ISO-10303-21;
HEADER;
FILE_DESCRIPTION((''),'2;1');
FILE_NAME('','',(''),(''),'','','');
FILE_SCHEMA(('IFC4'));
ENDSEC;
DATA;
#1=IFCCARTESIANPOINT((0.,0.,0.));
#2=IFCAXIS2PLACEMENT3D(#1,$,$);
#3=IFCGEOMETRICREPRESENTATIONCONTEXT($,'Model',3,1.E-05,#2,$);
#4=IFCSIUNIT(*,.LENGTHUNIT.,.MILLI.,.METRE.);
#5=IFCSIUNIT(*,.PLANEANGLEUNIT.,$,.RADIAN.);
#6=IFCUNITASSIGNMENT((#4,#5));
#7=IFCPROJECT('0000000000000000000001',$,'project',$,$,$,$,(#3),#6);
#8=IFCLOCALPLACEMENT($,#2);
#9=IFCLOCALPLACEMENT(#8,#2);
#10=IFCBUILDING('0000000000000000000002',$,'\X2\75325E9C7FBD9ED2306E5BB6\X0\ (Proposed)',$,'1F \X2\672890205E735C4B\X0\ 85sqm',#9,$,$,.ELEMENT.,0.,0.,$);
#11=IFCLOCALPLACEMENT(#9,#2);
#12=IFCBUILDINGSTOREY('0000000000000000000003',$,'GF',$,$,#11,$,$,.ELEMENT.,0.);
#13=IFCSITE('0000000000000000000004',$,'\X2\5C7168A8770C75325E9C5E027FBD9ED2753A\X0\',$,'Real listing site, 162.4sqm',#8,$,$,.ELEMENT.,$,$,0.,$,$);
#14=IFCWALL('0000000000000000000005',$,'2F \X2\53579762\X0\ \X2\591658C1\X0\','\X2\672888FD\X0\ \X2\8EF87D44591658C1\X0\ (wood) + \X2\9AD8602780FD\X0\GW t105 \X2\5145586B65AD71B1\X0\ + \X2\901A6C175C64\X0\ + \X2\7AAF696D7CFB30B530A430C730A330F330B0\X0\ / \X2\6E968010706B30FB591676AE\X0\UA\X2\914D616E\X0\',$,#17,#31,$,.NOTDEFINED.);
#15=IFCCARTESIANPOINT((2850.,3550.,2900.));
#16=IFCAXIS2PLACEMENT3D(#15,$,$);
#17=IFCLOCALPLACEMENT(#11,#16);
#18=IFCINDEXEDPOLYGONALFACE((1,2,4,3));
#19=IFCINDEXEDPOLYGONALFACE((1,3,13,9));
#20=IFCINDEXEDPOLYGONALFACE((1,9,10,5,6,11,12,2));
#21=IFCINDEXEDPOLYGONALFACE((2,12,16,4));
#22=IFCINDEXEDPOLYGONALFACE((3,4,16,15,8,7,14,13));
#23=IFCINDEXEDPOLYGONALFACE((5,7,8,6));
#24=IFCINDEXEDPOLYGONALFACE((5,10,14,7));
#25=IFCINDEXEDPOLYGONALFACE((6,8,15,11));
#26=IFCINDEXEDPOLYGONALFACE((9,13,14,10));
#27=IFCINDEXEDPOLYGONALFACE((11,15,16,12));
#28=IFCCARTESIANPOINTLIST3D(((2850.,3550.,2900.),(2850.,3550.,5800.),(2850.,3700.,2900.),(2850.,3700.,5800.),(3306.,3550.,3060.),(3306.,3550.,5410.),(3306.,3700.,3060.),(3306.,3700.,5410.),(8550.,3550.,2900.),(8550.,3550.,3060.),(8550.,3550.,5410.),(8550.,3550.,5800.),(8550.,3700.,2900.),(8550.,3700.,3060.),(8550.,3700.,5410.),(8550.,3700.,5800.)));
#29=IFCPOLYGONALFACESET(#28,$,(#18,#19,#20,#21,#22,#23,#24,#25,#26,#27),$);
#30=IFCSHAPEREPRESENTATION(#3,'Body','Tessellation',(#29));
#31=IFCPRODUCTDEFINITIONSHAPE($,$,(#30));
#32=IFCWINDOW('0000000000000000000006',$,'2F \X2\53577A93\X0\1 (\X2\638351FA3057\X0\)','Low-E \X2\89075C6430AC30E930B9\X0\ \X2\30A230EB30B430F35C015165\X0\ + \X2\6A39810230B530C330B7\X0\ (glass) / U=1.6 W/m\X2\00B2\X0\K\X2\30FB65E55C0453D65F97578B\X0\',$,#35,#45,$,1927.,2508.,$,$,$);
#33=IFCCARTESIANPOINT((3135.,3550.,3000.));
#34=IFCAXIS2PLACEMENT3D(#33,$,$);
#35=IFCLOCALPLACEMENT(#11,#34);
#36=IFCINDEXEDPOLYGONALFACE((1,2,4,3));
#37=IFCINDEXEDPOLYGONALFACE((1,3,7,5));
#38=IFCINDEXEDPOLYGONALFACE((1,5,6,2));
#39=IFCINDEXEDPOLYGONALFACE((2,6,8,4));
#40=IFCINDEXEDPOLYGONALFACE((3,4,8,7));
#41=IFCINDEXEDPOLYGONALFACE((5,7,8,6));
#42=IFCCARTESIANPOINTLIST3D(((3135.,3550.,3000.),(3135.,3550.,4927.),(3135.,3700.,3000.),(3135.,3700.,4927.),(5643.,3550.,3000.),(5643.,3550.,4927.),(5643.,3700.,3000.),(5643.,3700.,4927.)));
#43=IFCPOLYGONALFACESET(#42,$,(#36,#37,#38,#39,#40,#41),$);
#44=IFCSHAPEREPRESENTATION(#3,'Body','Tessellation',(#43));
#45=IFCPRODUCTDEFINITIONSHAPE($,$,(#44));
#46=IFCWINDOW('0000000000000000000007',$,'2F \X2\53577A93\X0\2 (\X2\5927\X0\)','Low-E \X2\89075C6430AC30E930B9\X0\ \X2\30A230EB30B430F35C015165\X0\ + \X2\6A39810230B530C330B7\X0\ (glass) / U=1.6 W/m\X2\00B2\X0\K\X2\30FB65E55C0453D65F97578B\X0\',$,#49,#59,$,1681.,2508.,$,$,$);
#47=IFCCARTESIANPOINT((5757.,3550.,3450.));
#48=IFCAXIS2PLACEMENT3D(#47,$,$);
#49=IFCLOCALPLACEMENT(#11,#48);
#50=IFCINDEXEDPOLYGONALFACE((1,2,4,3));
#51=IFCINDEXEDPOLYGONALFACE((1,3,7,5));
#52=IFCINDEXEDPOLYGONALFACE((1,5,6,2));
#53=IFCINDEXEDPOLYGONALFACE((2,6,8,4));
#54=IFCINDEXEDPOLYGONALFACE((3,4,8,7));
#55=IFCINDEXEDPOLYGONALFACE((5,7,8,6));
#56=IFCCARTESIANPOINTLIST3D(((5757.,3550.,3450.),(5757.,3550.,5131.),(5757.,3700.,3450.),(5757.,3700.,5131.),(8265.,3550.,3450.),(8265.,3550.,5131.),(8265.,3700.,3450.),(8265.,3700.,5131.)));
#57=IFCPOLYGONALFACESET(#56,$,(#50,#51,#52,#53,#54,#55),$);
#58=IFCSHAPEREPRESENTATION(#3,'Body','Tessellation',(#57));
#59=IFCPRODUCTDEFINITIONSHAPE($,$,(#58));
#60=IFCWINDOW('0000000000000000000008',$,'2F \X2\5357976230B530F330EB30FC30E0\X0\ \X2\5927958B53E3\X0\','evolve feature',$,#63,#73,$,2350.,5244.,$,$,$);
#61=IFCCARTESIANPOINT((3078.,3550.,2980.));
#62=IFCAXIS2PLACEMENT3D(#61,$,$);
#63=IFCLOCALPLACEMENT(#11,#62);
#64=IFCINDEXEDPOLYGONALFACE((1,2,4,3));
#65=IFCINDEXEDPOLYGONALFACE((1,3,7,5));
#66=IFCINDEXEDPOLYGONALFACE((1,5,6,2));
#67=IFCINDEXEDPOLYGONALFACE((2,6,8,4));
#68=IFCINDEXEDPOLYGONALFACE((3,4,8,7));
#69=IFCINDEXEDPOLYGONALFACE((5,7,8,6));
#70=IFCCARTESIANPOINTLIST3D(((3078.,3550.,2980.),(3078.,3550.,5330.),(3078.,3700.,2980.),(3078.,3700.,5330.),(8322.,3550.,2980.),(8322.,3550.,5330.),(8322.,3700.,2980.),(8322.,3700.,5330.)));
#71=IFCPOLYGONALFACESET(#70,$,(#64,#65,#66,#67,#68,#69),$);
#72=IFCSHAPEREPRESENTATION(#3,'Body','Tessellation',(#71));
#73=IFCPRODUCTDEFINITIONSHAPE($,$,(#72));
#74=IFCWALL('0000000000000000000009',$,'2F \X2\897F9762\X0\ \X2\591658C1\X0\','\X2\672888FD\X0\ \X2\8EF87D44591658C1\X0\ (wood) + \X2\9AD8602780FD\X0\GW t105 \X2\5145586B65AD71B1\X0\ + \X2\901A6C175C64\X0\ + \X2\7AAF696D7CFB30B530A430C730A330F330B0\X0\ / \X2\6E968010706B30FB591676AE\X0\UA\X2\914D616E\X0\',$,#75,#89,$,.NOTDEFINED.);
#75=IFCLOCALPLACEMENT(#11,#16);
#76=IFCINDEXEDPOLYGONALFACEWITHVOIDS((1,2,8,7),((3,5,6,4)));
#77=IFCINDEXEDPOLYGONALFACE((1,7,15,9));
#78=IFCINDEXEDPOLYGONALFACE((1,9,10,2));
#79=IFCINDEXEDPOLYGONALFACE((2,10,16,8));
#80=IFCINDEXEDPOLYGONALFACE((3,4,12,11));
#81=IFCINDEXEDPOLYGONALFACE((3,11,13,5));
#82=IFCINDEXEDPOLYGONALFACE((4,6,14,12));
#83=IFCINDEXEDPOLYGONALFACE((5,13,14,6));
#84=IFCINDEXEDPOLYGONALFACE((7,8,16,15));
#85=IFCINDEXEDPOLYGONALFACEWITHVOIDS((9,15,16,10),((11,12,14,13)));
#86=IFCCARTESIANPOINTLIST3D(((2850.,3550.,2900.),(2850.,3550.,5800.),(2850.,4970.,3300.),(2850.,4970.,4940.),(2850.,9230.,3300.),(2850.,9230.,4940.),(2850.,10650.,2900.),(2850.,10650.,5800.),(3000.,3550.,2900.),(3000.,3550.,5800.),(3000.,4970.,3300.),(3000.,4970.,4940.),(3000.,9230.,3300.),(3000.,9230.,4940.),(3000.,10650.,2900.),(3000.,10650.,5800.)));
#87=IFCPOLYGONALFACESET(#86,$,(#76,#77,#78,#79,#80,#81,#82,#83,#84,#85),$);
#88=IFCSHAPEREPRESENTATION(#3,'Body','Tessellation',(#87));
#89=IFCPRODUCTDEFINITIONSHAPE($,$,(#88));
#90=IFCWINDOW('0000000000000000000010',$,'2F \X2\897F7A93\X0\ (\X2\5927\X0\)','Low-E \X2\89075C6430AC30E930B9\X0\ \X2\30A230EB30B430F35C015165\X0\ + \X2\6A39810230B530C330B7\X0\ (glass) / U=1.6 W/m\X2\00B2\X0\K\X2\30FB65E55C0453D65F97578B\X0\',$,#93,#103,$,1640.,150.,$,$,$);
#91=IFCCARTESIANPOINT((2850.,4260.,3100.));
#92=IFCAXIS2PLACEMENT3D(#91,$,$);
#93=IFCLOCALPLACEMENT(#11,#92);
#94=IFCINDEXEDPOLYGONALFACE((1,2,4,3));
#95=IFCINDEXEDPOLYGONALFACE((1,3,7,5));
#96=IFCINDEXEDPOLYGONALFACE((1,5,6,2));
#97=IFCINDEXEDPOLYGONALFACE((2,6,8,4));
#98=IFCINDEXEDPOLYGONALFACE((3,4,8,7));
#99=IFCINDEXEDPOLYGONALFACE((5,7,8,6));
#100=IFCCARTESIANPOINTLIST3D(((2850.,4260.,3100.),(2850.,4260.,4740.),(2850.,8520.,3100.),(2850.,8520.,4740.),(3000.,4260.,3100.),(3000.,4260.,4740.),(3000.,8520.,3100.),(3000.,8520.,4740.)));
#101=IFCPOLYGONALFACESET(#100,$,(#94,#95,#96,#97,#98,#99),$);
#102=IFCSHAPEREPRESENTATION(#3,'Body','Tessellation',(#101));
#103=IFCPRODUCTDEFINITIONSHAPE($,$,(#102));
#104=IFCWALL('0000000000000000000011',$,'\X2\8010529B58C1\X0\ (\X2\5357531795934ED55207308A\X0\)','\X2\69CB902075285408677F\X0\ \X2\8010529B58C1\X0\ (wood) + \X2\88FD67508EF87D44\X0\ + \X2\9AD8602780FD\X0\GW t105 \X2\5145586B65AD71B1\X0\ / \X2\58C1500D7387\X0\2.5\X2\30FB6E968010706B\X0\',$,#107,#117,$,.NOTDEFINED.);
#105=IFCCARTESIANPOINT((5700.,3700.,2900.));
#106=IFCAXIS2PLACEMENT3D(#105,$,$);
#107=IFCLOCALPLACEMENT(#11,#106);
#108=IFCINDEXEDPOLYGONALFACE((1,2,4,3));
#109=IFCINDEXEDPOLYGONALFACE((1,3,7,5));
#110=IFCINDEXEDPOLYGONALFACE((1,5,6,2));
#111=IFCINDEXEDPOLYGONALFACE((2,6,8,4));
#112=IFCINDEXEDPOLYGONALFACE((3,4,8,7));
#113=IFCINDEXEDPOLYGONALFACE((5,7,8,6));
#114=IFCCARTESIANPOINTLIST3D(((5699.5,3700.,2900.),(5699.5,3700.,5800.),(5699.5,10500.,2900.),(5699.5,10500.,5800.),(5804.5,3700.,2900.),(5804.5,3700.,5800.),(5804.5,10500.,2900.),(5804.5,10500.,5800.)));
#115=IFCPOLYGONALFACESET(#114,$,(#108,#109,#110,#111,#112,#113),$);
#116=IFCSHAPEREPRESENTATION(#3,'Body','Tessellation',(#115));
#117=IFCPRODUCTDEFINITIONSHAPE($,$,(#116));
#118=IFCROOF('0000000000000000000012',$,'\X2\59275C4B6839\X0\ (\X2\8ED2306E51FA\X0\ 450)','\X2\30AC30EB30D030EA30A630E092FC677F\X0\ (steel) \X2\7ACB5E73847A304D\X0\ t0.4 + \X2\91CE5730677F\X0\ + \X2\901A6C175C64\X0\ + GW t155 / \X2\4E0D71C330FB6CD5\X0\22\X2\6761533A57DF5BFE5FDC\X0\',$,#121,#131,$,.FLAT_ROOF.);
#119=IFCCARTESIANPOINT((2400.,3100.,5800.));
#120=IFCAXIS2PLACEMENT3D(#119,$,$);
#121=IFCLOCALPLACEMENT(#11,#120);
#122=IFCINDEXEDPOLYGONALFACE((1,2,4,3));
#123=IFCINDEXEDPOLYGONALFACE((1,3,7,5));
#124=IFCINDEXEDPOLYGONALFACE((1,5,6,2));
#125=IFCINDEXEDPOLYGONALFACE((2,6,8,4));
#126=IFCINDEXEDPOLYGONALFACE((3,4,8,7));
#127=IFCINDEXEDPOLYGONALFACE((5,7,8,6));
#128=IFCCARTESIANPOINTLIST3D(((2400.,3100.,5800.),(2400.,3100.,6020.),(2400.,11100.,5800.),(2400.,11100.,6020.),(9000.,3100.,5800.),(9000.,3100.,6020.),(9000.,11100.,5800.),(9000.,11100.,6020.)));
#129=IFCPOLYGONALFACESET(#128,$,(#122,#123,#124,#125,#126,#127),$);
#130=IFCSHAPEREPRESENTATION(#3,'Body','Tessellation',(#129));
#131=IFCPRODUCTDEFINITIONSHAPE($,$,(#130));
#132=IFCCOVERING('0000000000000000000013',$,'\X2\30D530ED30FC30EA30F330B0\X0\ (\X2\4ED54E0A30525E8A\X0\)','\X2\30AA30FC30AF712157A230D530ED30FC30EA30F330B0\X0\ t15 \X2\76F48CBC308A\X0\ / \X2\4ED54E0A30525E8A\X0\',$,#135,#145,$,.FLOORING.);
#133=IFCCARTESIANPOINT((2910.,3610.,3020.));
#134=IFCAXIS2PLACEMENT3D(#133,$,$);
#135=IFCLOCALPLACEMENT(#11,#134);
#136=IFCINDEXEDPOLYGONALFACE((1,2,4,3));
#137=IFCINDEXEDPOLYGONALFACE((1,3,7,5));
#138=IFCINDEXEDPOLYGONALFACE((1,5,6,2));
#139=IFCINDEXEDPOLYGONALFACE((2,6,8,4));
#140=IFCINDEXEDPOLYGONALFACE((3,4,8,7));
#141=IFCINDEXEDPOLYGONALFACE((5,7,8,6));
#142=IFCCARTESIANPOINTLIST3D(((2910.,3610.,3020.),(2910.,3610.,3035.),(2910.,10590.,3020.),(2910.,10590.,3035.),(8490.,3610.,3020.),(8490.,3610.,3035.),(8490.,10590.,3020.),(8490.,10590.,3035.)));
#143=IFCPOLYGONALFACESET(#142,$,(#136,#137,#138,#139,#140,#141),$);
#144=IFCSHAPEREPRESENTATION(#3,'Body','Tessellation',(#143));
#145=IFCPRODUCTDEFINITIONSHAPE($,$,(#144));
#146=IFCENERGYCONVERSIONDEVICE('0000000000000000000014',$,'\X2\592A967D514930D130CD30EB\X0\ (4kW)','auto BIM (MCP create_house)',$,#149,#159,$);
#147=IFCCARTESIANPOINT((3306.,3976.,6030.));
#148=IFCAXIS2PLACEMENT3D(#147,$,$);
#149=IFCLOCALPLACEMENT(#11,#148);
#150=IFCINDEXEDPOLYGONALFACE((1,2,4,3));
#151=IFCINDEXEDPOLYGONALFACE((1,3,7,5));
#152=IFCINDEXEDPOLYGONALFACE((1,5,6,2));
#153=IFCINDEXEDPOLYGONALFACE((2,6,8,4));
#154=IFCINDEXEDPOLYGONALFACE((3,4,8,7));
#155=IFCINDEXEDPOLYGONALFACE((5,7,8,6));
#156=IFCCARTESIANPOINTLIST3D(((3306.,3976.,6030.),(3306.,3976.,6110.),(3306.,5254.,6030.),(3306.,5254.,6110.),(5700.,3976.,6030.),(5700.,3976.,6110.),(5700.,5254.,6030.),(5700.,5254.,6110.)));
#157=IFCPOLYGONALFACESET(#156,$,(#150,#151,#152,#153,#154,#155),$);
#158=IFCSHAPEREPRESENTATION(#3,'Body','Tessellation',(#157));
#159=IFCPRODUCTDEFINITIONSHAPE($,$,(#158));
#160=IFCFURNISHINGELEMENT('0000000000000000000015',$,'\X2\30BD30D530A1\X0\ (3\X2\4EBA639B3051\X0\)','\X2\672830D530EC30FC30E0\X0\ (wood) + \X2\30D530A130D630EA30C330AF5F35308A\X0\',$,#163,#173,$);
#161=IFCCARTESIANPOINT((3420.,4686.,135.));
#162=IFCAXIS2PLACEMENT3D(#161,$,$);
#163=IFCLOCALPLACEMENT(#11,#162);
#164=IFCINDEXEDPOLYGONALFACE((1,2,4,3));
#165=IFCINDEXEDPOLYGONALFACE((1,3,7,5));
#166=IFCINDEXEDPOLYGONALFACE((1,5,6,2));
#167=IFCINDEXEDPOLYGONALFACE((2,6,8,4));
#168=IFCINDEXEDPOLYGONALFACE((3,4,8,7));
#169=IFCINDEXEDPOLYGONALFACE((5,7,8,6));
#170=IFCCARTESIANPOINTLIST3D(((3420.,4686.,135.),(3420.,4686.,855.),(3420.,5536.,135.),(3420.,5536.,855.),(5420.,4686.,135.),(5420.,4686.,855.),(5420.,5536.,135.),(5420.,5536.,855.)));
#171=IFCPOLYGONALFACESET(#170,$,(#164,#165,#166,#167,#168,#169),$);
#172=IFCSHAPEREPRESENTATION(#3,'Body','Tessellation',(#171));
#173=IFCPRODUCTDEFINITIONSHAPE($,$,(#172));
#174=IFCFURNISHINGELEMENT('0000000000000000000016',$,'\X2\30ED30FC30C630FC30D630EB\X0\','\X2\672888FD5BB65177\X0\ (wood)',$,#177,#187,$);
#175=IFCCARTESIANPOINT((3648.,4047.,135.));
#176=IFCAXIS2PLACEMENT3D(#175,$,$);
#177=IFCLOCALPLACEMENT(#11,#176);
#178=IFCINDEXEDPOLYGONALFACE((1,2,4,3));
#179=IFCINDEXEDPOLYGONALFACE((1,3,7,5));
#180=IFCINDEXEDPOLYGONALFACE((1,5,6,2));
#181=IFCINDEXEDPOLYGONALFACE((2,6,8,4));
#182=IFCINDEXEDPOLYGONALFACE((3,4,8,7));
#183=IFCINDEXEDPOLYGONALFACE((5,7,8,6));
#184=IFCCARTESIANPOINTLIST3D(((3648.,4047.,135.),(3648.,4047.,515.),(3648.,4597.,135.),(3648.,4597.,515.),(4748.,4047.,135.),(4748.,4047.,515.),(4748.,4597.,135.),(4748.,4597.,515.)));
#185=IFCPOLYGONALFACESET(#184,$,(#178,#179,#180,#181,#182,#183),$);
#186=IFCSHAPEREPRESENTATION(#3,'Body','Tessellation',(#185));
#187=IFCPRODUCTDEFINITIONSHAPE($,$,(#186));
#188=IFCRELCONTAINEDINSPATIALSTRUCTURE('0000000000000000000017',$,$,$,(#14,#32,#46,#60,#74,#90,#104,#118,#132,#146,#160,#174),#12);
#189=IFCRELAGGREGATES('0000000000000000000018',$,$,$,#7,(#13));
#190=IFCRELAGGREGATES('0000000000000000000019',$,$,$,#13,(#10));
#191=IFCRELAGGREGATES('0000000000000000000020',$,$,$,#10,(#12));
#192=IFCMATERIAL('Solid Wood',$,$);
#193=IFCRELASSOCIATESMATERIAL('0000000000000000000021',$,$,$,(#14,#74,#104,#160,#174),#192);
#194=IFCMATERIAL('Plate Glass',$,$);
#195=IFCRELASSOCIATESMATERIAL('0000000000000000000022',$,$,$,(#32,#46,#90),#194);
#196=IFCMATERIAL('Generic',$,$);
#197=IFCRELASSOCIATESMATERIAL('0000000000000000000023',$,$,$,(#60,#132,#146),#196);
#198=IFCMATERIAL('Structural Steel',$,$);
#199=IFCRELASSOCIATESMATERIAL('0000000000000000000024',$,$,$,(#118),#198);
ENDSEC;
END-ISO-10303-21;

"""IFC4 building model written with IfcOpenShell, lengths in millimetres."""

from ifc_helpers import new_model, si_unit, frame, frame_2d, origin, place, context, project, spatial, rectangle, extrude, material, element, fill, save


model = new_model("IFC4")

# Units and contexts
model_context = context("Model", 3, precision=1e-05, world=origin())
ifc_project = project(units=[si_unit("LENGTHUNIT", "METRE", prefix="MILLI"), si_unit("PLANEANGLEUNIT", "RADIAN")], contexts=[model_context])

# Site, building, storey
site_placement = place(None, origin())
site = spatial("IfcSite", under=ifc_project, at=site_placement, Name="山梨県甲府市羽黒町", ObjectType="Real listing site, 162.4sqm", CompositionType="ELEMENT", RefElevation=0.0)
building_placement = place(site_placement, origin())
building = spatial("IfcBuilding", under=site, at=building_placement, Name="甲府羽黒の家 (Proposed)", ObjectType="1F 木造平屋 85sqm", CompositionType="ELEMENT", ElevationOfRefHeight=0.0, ElevationOfTerrain=0.0)
storey_placement = place(building_placement, origin())
storey = spatial("IfcBuildingStorey", under=building, at=storey_placement, Name="GF", CompositionType="ELEMENT", Elevation=0.0)

# Shared definitions
ifc_material_1 = material(Name="Solid Wood")

# Wall, openings, windows
wall_1_placement = place(storey_placement, frame((2850.0, 3550.0, 2900.0)))
wall_1 = element("IfcWall", 1, at=wall_1_placement, inside=storey, material=ifc_material_1, Name="2F 南面 外壁", Description="木製 軸組外壁 (wood) + 高性能GW t105 充填断熱 + 通気層 + 窯業系サイディング / 準耐火・外皮UA配慮", PredefinedType="NOTDEFINED", context=model_context, shape_type="SweptSolid", body=[
    extrude(rectangle(XDim=5700.0, YDim=150.0, at=frame_2d((2850.0, 75.0))), frame((2850.0, 3550.0, 2900.0)), (0.0, 0.0, 1.0), 2900.0),
])
opening_1_placement = place(storey_placement, frame((3135.0, 3550.0, 3000.0)))
opening_1 = element("IfcOpeningElement", 2, at=opening_1_placement, cuts=wall_1, PredefinedType="NOTDEFINED", context=model_context, shape_type="SweptSolid", body=[
    extrude(rectangle(XDim=2508.0, YDim=150.0, at=frame_2d((1254.0, 75.0))), frame((3135.0, 3550.0, 3000.0)), (0.0, 0.0, 1.0), 1927.0),
])
opening_2_placement = place(storey_placement, frame((5757.0, 3550.0, 3450.0)))
opening_2 = element("IfcOpeningElement", 3, at=opening_2_placement, cuts=wall_1, PredefinedType="NOTDEFINED", context=model_context, shape_type="SweptSolid", body=[
    extrude(rectangle(XDim=2508.0, YDim=150.0, at=frame_2d((1254.0, 75.0))), frame((5757.0, 3550.0, 3450.0)), (0.0, 0.0, 1.0), 1681.0),
])
opening_3_placement = place(storey_placement, frame((3078.0, 3550.0, 2980.0)))
opening_3 = element("IfcOpeningElement", 4, at=opening_3_placement, cuts=wall_1, PredefinedType="NOTDEFINED", context=model_context, shape_type="SweptSolid", body=[
    extrude(rectangle(XDim=5244.0, YDim=150.0, at=frame_2d((2622.0, 75.0))), frame((3078.0, 3550.0, 2980.0)), (0.0, 0.0, 1.0), 2350.0),
])
ifc_material_2 = material(Name="Plate Glass")
window_1_placement = place(storey_placement, frame((3135.0, 3550.0, 3000.0)))
window_1 = element("IfcWindow", 5, at=window_1_placement, inside=storey, material=ifc_material_2, Name="2F 南窓1 (掃出し)", Description="Low-E 複層ガラス アルゴン封入 + 樹脂サッシ (glass) / U=1.6 W/m²K・日射取得型", OverallHeight=1927.0, OverallWidth=2508.0, context=model_context, shape_type="SweptSolid", body=[
    extrude(rectangle(XDim=2508.0, YDim=150.0, at=frame_2d((1254.0, 75.0))), frame((3135.0, 3550.0, 3000.0)), (0.0, 0.0, 1.0), 1927.0),
])
fill(opening_1, window_1)
window_2_placement = place(storey_placement, frame((5757.0, 3550.0, 3450.0)))
window_2 = element("IfcWindow", 6, at=window_2_placement, inside=storey, material=ifc_material_2, Name="2F 南窓2 (大)", Description="Low-E 複層ガラス アルゴン封入 + 樹脂サッシ (glass) / U=1.6 W/m²K・日射取得型", OverallHeight=1681.0, OverallWidth=2508.0, context=model_context, shape_type="SweptSolid", body=[
    extrude(rectangle(XDim=2508.0, YDim=150.0, at=frame_2d((1254.0, 75.0))), frame((5757.0, 3550.0, 3450.0)), (0.0, 0.0, 1.0), 1681.0),
])
fill(opening_2, window_2)
ifc_material_3 = material(Name="Generic")
window_3_placement = place(storey_placement, frame((3078.0, 3550.0, 2980.0)))
window_3 = element("IfcWindow", 7, at=window_3_placement, inside=storey, material=ifc_material_3, Name="2F 南面サンルーム 大開口", Description="evolve feature", OverallHeight=2350.0, OverallWidth=5244.0, context=model_context, shape_type="SweptSolid", body=[
    extrude(rectangle(XDim=5244.0, YDim=150.0, at=frame_2d((2622.0, 75.0))), frame((3078.0, 3550.0, 2980.0)), (0.0, 0.0, 1.0), 2350.0),
])
fill(opening_3, window_3)

# Wall, opening, window
wall_2_placement = place(storey_placement, frame((2850.0, 3550.0, 2900.0)))
wall_2 = element("IfcWall", 8, at=wall_2_placement, inside=storey, material=ifc_material_1, Name="2F 西面 外壁", Description="木製 軸組外壁 (wood) + 高性能GW t105 充填断熱 + 通気層 + 窯業系サイディング / 準耐火・外皮UA配慮", PredefinedType="NOTDEFINED", context=model_context, shape_type="SweptSolid", body=[
    extrude(rectangle(XDim=150.0, YDim=7100.0, at=frame_2d((75.0, 3550.0))), frame((2850.0, 3550.0, 2900.0)), (0.0, 0.0, 1.0), 2900.0),
])
opening_4_placement = place(storey_placement, frame((2850.0, 4260.0, 3100.0)))
opening_4 = element("IfcOpeningElement", 9, at=opening_4_placement, cuts=wall_2, PredefinedType="NOTDEFINED", context=model_context, shape_type="SweptSolid", body=[
    extrude(rectangle(XDim=150.0, YDim=4260.0, at=frame_2d((75.0, 2130.0))), frame((2850.0, 4260.0, 3100.0)), (0.0, 0.0, 1.0), 1640.0),
])
window_4_placement = place(storey_placement, frame((2850.0, 4260.0, 3100.0)))
window_4 = element("IfcWindow", 10, at=window_4_placement, inside=storey, material=ifc_material_2, Name="2F 西窓 (大)", Description="Low-E 複層ガラス アルゴン封入 + 樹脂サッシ (glass) / U=1.6 W/m²K・日射取得型", OverallHeight=1640.0, OverallWidth=150.0, context=model_context, shape_type="SweptSolid", body=[
    extrude(rectangle(XDim=150.0, YDim=4260.0, at=frame_2d((75.0, 2130.0))), frame((2850.0, 4260.0, 3100.0)), (0.0, 0.0, 1.0), 1640.0),
])
fill(opening_4, window_4)

# Wall
wall_3_placement = place(storey_placement, frame((5700.0, 3700.0, 2900.0)))
element("IfcWall", 11, at=wall_3_placement, inside=storey, material=ifc_material_1, Name="耐力壁 (南北間仕切り)", Description="構造用合板 耐力壁 (wood) + 製材軸組 + 高性能GW t105 充填断熱 / 壁倍率2.5・準耐火", PredefinedType="NOTDEFINED", context=model_context, shape_type="SweptSolid", body=[
    extrude(rectangle(XDim=105.0, YDim=6800.0, at=frame_2d((52.0, 3400.0))), frame((5700.0, 3700.0, 2900.0)), (0.0, 0.0, 1.0), 2900.0),
])

# Roof
ifc_material_4 = material(Name="Structural Steel")
roof_placement = place(storey_placement, frame((2400.0, 3100.0, 5800.0)))
element("IfcRoof", 12, at=roof_placement, inside=storey, material=ifc_material_4, Name="大屋根 (軒の出 450)", Description="ガルバリウム鋼板 (steel) 立平葺き t0.4 + 野地板 + 通気層 + GW t155 / 不燃・法22条区域対応", PredefinedType="FLAT_ROOF", context=model_context, shape_type="SweptSolid", body=[
    extrude(rectangle(XDim=6600.0, YDim=8000.0, at=frame_2d((3300.0, 4000.0))), frame((2400.0, 3100.0, 5800.0)), (0.0, 0.0, 1.0), 220.0),
])

# Covering
covering_placement = place(storey_placement, frame((2910.0, 3610.0, 3020.0)))
element("IfcCovering", 13, at=covering_placement, inside=storey, material=ifc_material_3, Name="フローリング (仕上げ床)", Description="オーク無垢フローリング t15 直貼り / 仕上げ床", PredefinedType="FLOORING", context=model_context, shape_type="SweptSolid", body=[
    extrude(rectangle(XDim=5580.0, YDim=6980.0, at=frame_2d((2790.0, 3490.0))), frame((2910.0, 3610.0, 3020.0)), (0.0, 0.0, 1.0), 15.0),
])

# Energy conversion device
energy_conversion_device_placement = place(storey_placement, frame((3306.0, 3976.0, 6030.0)))
element("IfcEnergyConversionDevice", 14, at=energy_conversion_device_placement, inside=storey, material=ifc_material_3, Name="太陽光パネル (4kW)", Description="auto BIM (MCP create_house)", context=model_context, shape_type="SweptSolid", body=[
    extrude(rectangle(XDim=2394.0, YDim=1278.0, at=frame_2d((1197.0, 639.0))), frame((3306.0, 3976.0, 6030.0)), (0.0, 0.0, 1.0), 80.0),
])

# Furnishing elements
furnishing_1_placement = place(storey_placement, frame((3420.0, 4686.0, 135.0)))
element("IfcFurnishingElement", 15, at=furnishing_1_placement, inside=storey, material=ifc_material_1, Name="ソファ (3人掛け)", Description="木フレーム (wood) + ファブリック張り", context=model_context, shape_type="SweptSolid", body=[
    extrude(rectangle(XDim=2000.0, YDim=850.0, at=frame_2d((1000.0, 425.0))), frame((3420.0, 4686.0, 135.0)), (0.0, 0.0, 1.0), 720.0),
])
furnishing_2_placement = place(storey_placement, frame((3648.0, 4047.0, 135.0)))
element("IfcFurnishingElement", 16, at=furnishing_2_placement, inside=storey, material=ifc_material_1, Name="ローテーブル", Description="木製家具 (wood)", context=model_context, shape_type="SweptSolid", body=[
    extrude(rectangle(XDim=1100.0, YDim=550.0, at=frame_2d((550.0, 275.0))), frame((3648.0, 4047.0, 135.0)), (0.0, 0.0, 1.0), 380.0),
])

save(model, "model.ifc")
